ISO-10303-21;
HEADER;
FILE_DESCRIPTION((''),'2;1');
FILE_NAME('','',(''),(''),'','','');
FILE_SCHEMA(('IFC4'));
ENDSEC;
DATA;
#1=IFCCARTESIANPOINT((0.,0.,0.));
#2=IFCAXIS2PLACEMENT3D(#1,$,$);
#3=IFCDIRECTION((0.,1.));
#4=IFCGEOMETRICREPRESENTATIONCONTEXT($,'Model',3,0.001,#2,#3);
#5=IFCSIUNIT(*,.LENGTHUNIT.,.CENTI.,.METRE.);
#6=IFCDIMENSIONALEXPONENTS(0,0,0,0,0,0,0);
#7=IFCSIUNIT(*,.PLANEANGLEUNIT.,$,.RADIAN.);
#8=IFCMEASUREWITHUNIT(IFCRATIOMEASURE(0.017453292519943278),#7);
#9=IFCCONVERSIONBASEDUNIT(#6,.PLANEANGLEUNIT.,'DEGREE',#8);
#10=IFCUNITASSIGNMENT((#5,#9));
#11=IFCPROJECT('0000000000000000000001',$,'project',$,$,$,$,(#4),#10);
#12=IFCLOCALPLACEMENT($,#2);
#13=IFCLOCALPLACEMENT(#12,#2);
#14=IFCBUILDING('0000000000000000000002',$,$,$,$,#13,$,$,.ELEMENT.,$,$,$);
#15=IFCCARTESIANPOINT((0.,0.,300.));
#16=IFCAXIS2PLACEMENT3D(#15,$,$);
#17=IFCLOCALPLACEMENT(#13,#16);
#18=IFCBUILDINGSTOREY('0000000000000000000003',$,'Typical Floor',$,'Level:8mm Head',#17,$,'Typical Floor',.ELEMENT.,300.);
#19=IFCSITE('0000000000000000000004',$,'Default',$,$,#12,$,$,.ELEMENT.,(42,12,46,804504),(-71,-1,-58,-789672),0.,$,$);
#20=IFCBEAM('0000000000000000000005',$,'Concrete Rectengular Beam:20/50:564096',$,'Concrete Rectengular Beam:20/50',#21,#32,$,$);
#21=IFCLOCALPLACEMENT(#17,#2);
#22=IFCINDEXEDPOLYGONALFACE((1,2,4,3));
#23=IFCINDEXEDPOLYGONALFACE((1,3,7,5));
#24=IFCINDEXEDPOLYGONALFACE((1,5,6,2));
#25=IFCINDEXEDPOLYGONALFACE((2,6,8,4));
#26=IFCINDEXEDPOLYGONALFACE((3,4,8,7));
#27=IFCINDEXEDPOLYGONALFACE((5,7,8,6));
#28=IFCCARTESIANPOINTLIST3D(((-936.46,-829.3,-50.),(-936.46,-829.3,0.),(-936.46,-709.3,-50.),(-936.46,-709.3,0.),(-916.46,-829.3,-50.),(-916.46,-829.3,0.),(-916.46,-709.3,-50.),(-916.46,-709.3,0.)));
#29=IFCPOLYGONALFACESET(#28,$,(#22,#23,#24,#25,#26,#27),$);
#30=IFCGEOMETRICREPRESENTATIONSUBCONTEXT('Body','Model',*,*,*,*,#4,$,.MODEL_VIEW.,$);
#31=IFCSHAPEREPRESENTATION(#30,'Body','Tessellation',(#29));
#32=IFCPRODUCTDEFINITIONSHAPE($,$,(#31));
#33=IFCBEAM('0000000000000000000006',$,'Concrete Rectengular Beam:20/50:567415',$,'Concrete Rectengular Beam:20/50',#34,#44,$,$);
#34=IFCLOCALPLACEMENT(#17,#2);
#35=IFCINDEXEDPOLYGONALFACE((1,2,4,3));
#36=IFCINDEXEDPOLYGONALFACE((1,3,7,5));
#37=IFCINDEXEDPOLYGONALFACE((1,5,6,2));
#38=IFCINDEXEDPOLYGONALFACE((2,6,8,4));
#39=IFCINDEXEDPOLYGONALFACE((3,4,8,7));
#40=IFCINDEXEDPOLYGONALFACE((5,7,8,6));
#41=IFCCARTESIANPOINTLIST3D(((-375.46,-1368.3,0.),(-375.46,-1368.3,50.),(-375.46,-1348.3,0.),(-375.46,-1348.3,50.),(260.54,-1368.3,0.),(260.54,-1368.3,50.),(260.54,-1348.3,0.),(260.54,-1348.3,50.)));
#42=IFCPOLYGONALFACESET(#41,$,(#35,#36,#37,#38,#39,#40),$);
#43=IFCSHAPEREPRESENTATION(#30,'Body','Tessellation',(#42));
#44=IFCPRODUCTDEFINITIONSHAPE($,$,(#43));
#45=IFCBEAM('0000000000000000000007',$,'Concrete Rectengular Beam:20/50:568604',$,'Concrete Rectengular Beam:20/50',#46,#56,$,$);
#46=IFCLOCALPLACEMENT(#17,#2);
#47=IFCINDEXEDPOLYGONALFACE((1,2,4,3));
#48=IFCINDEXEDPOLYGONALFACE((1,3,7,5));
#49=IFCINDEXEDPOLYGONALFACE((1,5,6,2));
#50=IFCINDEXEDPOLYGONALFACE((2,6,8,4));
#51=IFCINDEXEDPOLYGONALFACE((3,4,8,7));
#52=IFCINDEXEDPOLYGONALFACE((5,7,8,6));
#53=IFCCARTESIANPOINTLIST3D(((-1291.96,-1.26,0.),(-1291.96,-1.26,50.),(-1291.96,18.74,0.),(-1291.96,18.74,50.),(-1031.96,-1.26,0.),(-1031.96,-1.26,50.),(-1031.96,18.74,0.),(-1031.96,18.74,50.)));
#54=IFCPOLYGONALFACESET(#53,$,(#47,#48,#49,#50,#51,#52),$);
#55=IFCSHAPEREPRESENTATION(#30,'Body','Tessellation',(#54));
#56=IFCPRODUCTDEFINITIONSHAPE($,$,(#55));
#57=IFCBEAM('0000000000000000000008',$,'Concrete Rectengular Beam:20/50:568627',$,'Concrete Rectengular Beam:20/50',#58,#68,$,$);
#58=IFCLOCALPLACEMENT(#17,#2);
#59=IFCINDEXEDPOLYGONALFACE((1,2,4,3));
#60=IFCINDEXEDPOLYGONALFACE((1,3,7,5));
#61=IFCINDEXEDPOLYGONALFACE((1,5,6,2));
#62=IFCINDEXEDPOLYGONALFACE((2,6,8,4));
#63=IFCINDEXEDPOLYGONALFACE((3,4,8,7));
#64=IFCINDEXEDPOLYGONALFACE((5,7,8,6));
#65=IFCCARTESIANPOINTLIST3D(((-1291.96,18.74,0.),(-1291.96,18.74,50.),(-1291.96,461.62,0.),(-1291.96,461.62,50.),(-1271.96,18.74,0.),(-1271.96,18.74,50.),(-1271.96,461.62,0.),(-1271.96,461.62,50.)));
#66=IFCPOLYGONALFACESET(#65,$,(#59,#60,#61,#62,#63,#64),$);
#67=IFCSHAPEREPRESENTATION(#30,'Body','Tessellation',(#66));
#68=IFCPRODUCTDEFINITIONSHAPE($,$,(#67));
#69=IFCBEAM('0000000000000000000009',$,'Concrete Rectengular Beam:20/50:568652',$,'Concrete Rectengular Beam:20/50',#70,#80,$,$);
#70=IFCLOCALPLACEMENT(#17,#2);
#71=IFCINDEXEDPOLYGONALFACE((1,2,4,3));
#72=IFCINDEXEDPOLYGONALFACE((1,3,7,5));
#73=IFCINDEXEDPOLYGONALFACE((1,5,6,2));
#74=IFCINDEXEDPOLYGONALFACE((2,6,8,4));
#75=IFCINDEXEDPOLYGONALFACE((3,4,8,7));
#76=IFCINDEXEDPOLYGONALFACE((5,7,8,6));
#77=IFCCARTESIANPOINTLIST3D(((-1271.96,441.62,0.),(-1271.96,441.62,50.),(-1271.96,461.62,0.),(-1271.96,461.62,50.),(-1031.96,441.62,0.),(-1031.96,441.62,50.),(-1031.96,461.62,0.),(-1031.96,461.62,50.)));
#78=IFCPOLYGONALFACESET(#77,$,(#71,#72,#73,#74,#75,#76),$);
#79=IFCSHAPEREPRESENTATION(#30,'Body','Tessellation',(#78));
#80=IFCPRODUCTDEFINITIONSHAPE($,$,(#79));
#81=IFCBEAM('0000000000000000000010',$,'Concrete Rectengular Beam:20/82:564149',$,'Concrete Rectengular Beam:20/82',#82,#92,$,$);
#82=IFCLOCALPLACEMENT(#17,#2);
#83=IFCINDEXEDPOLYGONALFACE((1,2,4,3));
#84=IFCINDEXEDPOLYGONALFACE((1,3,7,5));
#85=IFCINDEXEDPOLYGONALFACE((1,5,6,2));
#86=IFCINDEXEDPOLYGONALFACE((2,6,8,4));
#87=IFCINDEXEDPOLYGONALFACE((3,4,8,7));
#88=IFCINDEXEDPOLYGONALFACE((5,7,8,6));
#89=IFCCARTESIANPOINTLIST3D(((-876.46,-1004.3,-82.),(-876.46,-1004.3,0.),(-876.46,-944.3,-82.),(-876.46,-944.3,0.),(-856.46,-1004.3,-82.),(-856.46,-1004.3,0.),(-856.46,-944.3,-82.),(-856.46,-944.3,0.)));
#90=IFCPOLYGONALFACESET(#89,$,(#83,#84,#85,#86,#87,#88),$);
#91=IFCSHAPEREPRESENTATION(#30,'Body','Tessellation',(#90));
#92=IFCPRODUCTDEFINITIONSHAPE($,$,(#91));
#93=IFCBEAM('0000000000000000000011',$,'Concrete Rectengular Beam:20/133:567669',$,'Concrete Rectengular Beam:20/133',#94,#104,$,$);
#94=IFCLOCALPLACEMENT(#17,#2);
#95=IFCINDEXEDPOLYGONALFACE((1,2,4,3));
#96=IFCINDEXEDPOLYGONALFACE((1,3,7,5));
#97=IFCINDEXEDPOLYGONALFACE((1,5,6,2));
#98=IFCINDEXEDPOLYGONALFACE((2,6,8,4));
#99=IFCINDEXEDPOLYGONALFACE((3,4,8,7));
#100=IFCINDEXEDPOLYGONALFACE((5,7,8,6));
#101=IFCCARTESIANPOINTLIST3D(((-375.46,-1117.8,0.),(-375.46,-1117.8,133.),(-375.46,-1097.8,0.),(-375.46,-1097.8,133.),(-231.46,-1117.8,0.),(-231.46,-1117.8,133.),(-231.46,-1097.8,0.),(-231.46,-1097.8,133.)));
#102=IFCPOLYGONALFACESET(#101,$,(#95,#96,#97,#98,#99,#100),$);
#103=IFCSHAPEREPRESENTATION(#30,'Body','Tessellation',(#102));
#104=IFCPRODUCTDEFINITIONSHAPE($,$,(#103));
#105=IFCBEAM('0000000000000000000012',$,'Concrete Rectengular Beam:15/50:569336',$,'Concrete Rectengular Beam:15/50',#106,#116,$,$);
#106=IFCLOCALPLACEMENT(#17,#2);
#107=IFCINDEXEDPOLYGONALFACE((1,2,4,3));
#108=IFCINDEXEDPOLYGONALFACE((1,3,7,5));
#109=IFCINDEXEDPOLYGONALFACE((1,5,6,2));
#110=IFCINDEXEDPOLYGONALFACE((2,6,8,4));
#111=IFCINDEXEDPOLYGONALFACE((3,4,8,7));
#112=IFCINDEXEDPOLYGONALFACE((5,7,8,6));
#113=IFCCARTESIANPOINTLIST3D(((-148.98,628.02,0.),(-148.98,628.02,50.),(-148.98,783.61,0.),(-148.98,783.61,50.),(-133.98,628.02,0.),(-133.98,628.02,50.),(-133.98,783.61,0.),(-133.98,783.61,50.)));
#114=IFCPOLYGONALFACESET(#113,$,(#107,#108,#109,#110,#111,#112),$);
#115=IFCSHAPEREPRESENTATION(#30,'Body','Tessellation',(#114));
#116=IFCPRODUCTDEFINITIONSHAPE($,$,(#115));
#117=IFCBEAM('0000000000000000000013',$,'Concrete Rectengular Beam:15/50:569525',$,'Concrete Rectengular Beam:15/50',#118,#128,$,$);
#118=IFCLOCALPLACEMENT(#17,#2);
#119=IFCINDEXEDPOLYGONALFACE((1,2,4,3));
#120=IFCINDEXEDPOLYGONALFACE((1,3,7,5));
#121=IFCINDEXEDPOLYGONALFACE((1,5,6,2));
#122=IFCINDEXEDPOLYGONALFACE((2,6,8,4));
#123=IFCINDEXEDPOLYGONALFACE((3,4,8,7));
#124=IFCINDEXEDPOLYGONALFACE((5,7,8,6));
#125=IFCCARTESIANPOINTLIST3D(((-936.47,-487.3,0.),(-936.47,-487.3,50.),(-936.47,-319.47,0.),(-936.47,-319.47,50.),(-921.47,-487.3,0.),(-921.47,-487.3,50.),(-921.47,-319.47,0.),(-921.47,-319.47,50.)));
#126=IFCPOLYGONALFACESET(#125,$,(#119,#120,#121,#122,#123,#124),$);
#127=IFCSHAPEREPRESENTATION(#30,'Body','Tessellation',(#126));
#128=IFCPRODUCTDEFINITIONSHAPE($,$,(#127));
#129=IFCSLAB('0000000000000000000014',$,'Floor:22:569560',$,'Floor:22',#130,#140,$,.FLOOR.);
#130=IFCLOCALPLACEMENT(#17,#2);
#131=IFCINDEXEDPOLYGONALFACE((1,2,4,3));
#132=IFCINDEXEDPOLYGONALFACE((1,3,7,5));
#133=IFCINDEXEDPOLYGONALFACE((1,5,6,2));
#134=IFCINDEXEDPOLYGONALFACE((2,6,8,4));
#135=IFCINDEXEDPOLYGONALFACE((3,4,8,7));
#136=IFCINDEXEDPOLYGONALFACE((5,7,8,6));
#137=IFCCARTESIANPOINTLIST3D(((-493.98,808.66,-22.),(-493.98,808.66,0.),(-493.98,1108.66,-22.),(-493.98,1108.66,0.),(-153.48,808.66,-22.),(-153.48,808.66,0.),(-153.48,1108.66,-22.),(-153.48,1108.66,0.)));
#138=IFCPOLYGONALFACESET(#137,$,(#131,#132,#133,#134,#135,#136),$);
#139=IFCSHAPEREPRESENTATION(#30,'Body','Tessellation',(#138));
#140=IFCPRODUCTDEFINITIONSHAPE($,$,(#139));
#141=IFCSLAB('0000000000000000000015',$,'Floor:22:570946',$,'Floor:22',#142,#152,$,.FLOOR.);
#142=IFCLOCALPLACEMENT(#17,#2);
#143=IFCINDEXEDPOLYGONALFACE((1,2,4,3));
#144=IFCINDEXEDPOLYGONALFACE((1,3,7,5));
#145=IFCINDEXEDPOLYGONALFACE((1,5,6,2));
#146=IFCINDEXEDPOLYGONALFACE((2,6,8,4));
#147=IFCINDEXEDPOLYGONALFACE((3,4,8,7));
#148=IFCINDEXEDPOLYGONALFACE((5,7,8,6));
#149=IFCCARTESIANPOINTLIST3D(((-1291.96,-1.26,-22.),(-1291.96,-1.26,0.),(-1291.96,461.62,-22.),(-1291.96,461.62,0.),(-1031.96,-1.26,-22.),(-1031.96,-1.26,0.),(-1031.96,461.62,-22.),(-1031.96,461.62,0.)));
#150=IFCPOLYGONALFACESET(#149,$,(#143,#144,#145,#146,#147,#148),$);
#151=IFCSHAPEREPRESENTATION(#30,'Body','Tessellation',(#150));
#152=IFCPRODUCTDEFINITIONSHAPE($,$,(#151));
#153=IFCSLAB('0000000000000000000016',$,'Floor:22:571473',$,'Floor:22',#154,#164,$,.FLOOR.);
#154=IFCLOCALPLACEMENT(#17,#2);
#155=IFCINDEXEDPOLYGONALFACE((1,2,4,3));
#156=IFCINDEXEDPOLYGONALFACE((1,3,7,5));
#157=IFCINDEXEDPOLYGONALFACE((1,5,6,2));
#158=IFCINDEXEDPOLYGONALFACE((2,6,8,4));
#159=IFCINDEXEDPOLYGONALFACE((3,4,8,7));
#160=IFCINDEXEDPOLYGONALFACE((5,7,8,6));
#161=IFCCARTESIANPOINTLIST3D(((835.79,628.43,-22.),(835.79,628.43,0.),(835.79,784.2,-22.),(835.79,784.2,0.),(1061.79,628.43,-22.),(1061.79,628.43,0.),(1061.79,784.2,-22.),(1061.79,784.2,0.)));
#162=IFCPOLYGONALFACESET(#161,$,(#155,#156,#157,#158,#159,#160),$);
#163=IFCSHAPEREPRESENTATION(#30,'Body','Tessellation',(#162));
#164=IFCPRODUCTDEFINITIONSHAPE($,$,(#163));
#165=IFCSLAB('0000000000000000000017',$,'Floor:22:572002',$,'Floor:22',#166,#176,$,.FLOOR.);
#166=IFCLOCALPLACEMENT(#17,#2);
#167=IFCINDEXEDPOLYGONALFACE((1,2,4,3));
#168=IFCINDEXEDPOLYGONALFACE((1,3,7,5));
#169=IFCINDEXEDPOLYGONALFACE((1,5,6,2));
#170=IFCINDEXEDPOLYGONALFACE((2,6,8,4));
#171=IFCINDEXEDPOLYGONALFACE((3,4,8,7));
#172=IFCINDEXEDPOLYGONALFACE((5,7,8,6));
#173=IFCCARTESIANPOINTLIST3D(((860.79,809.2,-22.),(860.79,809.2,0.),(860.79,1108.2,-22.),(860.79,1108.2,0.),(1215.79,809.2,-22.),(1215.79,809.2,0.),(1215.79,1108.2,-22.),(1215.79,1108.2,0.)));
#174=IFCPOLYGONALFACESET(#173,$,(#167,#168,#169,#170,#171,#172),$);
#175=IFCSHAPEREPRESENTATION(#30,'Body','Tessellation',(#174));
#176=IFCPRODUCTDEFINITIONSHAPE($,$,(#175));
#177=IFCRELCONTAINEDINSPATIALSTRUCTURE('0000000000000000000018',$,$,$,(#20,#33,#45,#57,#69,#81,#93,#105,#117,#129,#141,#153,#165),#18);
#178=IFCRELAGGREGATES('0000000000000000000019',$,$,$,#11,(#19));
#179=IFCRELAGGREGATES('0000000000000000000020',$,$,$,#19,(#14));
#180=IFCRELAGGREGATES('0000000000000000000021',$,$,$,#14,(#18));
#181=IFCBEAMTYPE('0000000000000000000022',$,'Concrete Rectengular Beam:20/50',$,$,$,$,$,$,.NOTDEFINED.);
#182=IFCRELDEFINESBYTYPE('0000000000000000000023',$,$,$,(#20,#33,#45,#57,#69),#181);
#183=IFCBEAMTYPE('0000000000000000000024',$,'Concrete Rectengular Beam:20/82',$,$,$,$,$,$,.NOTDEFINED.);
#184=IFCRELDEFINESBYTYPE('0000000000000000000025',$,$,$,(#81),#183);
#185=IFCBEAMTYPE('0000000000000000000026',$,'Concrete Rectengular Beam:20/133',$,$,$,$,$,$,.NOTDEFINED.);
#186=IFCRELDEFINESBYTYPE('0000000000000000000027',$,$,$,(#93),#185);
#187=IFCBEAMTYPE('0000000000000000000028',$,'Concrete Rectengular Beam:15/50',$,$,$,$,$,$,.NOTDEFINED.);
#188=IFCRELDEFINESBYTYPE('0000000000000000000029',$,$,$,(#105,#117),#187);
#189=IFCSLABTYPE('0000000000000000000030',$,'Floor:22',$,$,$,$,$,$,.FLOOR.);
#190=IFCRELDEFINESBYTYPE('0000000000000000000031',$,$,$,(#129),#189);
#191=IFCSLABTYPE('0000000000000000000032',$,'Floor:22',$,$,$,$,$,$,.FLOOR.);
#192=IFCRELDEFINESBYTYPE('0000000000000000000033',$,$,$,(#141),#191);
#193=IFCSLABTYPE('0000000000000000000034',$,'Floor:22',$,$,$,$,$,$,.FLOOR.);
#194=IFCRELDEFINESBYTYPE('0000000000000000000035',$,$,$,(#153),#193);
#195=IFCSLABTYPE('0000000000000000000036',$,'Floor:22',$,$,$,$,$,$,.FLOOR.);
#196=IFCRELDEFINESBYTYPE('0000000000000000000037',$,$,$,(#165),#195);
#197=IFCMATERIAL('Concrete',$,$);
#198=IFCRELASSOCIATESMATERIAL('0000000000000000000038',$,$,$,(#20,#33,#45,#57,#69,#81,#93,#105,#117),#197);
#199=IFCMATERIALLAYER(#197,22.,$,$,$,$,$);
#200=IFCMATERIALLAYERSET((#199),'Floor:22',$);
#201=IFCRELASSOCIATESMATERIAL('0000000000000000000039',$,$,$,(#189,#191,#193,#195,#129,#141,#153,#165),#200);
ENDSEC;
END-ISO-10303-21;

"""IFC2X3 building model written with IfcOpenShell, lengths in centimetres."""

from ifc_helpers import new_model, entity, si_unit, converted_unit, direction, frame, frame_2d, origin, origin_2d_with_axis, place, context, subcontext, project, spatial, rectangle, extrude, material, layer, layer_set, layer_usage, type_object, element, save


model = new_model("IFC2X3")

# Units and contexts
model_context = context("Model", 3, precision=0.001, world=origin(), true_north=direction((0.0, 1.0)))
body_context = subcontext(model_context, "Body", "Model", "MODEL_VIEW")
ifc_project = project(units=[si_unit("LENGTHUNIT", "METRE", prefix="CENTI"), converted_unit("PLANEANGLEUNIT", "DEGREE", entity("IfcRatioMeasure", 0.017453292519943278), si_unit("PLANEANGLEUNIT", "RADIAN"), dimensions=[0, 0, 0, 0, 0, 0, 0])], contexts=[model_context])

# Site, building, storey
site_placement = place(None, origin())
site = spatial("IfcSite", under=ifc_project, at=site_placement, Name="Default", CompositionType="ELEMENT", RefLatitude=(42, 12, 46, 804504), RefLongitude=(-71, -1, -58, -789672), RefElevation=0.0)
building_placement = place(site_placement, origin())
building = spatial("IfcBuilding", under=site, at=building_placement, CompositionType="ELEMENT")
storey_placement = place(building_placement, frame((0.0, 0.0, 300.0)))
storey = spatial("IfcBuildingStorey", under=building, at=storey_placement, Name="Typical Floor", ObjectType="Level:8mm Head", LongName="Typical Floor", CompositionType="ELEMENT", Elevation=300.0)

# Beams
ifc_material = material(Name="Concrete")
beam_type_1 = type_object("IfcBeamType", Name="Concrete Rectengular Beam:20/50", PredefinedType="NOTDEFINED")
beam_1_placement = place(storey_placement, frame((-926.46, -699.3, 0.0), z_axis=(0.0, 0.0, 1.0), x_axis=(0.0, -1.0, 0.0)))
element("IfcBeam", 1, at=beam_1_placement, inside=storey, type_object=beam_type_1, material=ifc_material, Name="Concrete Rectengular Beam:20/50:564096", ObjectType="Concrete Rectengular Beam:20/50", context=body_context, shape_type="SweptSolid", body=[
    extrude(rectangle(XDim=50.0, YDim=20.0, at=origin_2d_with_axis()), frame((10.0, 0.0, -25.0), z_axis=(1.0, 0.0, 0.0), x_axis=(0.0, 0.0, -1.0)), (0.0, 0.0, 1.0), 120.0),
])
beam_2_placement = place(storey_placement, frame((-375.46, -1358.3, 0.0)))
element("IfcBeam", 2, at=beam_2_placement, inside=storey, type_object=beam_type_1, material=ifc_material, Name="Concrete Rectengular Beam:20/50:567415", ObjectType="Concrete Rectengular Beam:20/50", context=body_context, shape_type="SweptSolid", body=[
    extrude(rectangle(XDim=50.0, YDim=20.0, at=frame_2d((0.0, 0.0), x_axis=(1.0, 0.0))), frame((0.0, 0.0, 25.0), z_axis=(1.0, 0.0, 0.0), x_axis=(0.0, 0.0, -1.0)), (0.0, 0.0, 1.0), 636.0),
])
beam_3_placement = place(storey_placement, frame((-1031.96, 8.74, 0.0), z_axis=(0.0, 0.0, 1.0), x_axis=(-1.0, 0.0, 0.0)))
element("IfcBeam", 3, at=beam_3_placement, inside=storey, type_object=beam_type_1, material=ifc_material, Name="Concrete Rectengular Beam:20/50:568604", ObjectType="Concrete Rectengular Beam:20/50", context=body_context, shape_type="SweptSolid", body=[
    extrude(rectangle(XDim=50.0, YDim=20.0, at=frame_2d((0.0, 0.0), x_axis=(1.0, 0.0))), frame((0.0, 0.0, 25.0), z_axis=(1.0, 0.0, 0.0), x_axis=(0.0, 0.0, -1.0)), (0.0, 0.0, 1.0), 260.0),
])
beam_4_placement = place(storey_placement, frame((-1281.96, 8.74, 0.0), z_axis=(0.0, 0.0, 1.0), x_axis=(0.0, 1.0, 0.0)))
element("IfcBeam", 4, at=beam_4_placement, inside=storey, type_object=beam_type_1, material=ifc_material, Name="Concrete Rectengular Beam:20/50:568627", ObjectType="Concrete Rectengular Beam:20/50", context=body_context, shape_type="SweptSolid", body=[
    extrude(rectangle(XDim=50.0, YDim=20.0, at=frame_2d((0.0, 0.0), x_axis=(1.0, 0.0))), frame((10.0, 0.0, 25.0), z_axis=(1.0, 0.0, 0.0), x_axis=(0.0, 0.0, -1.0)), (0.0, 0.0, 1.0), 442.88),
])
beam_5_placement = place(storey_placement, frame((-1281.96, 451.62, 0.0)))
element("IfcBeam", 5, at=beam_5_placement, inside=storey, type_object=beam_type_1, material=ifc_material, Name="Concrete Rectengular Beam:20/50:568652", ObjectType="Concrete Rectengular Beam:20/50", context=body_context, shape_type="SweptSolid", body=[
    extrude(rectangle(XDim=50.0, YDim=20.0, at=frame_2d((0.0, 0.0), x_axis=(1.0, 0.0))), frame((10.0, 0.0, 25.0), z_axis=(1.0, 0.0, 0.0), x_axis=(0.0, 0.0, -1.0)), (0.0, 0.0, 1.0), 240.0),
])
beam_type_2 = type_object("IfcBeamType", Name="Concrete Rectengular Beam:20/82", PredefinedType="NOTDEFINED")
beam_6_placement = place(storey_placement, frame((-866.46, -934.3, 0.0), z_axis=(0.0, 0.0, 1.0), x_axis=(0.0, -1.0, 0.0)))
element("IfcBeam", 6, at=beam_6_placement, inside=storey, type_object=beam_type_2, material=ifc_material, Name="Concrete Rectengular Beam:20/82:564149", ObjectType="Concrete Rectengular Beam:20/82", context=body_context, shape_type="SweptSolid", body=[
    extrude(rectangle(XDim=82.0, YDim=20.0, at=frame_2d((0.0, 0.0), x_axis=(1.0, 0.0))), frame((10.0, 0.0, -41.0), z_axis=(1.0, 0.0, 0.0), x_axis=(0.0, 0.0, -1.0)), (0.0, 0.0, 1.0), 60.0),
])
beam_type_3 = type_object("IfcBeamType", Name="Concrete Rectengular Beam:20/133", PredefinedType="NOTDEFINED")
beam_7_placement = place(storey_placement, frame((-231.46, -1107.8, 0.0), z_axis=(0.0, 0.0, 1.0), x_axis=(-1.0, 0.0, 0.0)))
element("IfcBeam", 7, at=beam_7_placement, inside=storey, type_object=beam_type_3, material=ifc_material, Name="Concrete Rectengular Beam:20/133:567669", ObjectType="Concrete Rectengular Beam:20/133", context=body_context, shape_type="SweptSolid", body=[
    extrude(rectangle(XDim=133.0, YDim=20.0, at=frame_2d((0.0, 0.0), x_axis=(1.0, 0.0))), frame((0.0, 0.0, 66.5), z_axis=(1.0, 0.0, 0.0), x_axis=(0.0, 0.0, -1.0)), (0.0, 0.0, 1.0), 144.0),
])
beam_type_4 = type_object("IfcBeamType", Name="Concrete Rectengular Beam:15/50", PredefinedType="NOTDEFINED")
beam_8_placement = place(storey_placement, frame((-141.48, 628.02, 0.0), z_axis=(0.0, 0.0, 1.0), x_axis=(0.0, 1.0, 0.0)))
element("IfcBeam", 8, at=beam_8_placement, inside=storey, type_object=beam_type_4, material=ifc_material, Name="Concrete Rectengular Beam:15/50:569336", ObjectType="Concrete Rectengular Beam:15/50", context=body_context, shape_type="SweptSolid", body=[
    extrude(rectangle(XDim=50.0, YDim=15.0, at=origin_2d_with_axis()), frame((0.0, 0.0, 25.0), z_axis=(1.0, 0.0, 0.0), x_axis=(0.0, 0.0, -1.0)), (0.0, 0.0, 1.0), 155.59),
])
beam_9_placement = place(storey_placement, frame((-928.97, -487.3, 0.0), z_axis=(0.0, 0.0, 1.0), x_axis=(0.0, 1.0, 0.0)))
element("IfcBeam", 9, at=beam_9_placement, inside=storey, type_object=beam_type_4, material=ifc_material, Name="Concrete Rectengular Beam:15/50:569525", ObjectType="Concrete Rectengular Beam:15/50", context=body_context, shape_type="SweptSolid", body=[
    extrude(rectangle(XDim=50.0, YDim=15.0, at=frame_2d((0.0, 0.0), x_axis=(1.0, 0.0))), frame((0.0, 0.0, 25.0), z_axis=(1.0, 0.0, 0.0), x_axis=(0.0, 0.0, -1.0)), (0.0, 0.0, 1.0), 167.82),
])

# Slabs
ifc_layer = layer(ifc_material, 22.0)
ifc_layer_set = layer_set([ifc_layer], Name="Floor:22")
ifc_layer_usage_1 = layer_usage(ifc_layer_set, "AXIS3", "POSITIVE", 0.0)
slab_type_1 = type_object("IfcSlabType", Name="Floor:22", PredefinedType="FLOOR", material=ifc_layer_set)
slab_1_placement = place(storey_placement, origin())
element("IfcSlab", 10, at=slab_1_placement, inside=storey, type_object=slab_type_1, material=ifc_layer_usage_1, Name="Floor:22:569560", ObjectType="Floor:22", PredefinedType="FLOOR", context=body_context, shape_type="SweptSolid", body=[
    extrude(rectangle(XDim=300.0, YDim=340.5, at=frame_2d((0.0, 0.0), x_axis=(1.0, 0.0))), frame((-323.73, 958.66, 0.0), z_axis=(0.0, 0.0, -1.0), x_axis=(0.0, 1.0, 0.0)), (0.0, 0.0, 1.0), 22.0),
])
ifc_layer_usage_2 = layer_usage(ifc_layer_set, "AXIS3", "POSITIVE", 0.0)
slab_type_2 = type_object("IfcSlabType", Name="Floor:22", PredefinedType="FLOOR", material=ifc_layer_set)
slab_2_placement = place(storey_placement, origin())
element("IfcSlab", 11, at=slab_2_placement, inside=storey, type_object=slab_type_2, material=ifc_layer_usage_2, Name="Floor:22:570946", ObjectType="Floor:22", PredefinedType="FLOOR", context=body_context, shape_type="SweptSolid", body=[
    extrude(rectangle(XDim=462.88, YDim=260.0, at=frame_2d((0.0, 0.0), x_axis=(1.0, 0.0))), frame((-1161.96, 230.18, 0.0), z_axis=(0.0, 0.0, -1.0), x_axis=(0.0, 1.0, 0.0)), (0.0, 0.0, 1.0), 22.0),
])
ifc_layer_usage_3 = layer_usage(ifc_layer_set, "AXIS3", "POSITIVE", 0.0)
slab_type_3 = type_object("IfcSlabType", Name="Floor:22", PredefinedType="FLOOR", material=ifc_layer_set)
slab_3_placement = place(storey_placement, origin())
element("IfcSlab", 12, at=slab_3_placement, inside=storey, type_object=slab_type_3, material=ifc_layer_usage_3, Name="Floor:22:571473", ObjectType="Floor:22", PredefinedType="FLOOR", context=body_context, shape_type="SweptSolid", body=[
    extrude(rectangle(XDim=155.77, YDim=226.0, at=frame_2d((0.0, 0.0), x_axis=(1.0, 0.0))), frame((948.79, 706.32, 0.0), z_axis=(0.0, 0.0, -1.0), x_axis=(0.0, 1.0, 0.0)), (0.0, 0.0, 1.0), 22.0),
])
ifc_layer_usage_4 = layer_usage(ifc_layer_set, "AXIS3", "POSITIVE", 0.0)
slab_type_4 = type_object("IfcSlabType", Name="Floor:22", PredefinedType="FLOOR", material=ifc_layer_set)
slab_4_placement = place(storey_placement, origin())
element("IfcSlab", 13, at=slab_4_placement, inside=storey, type_object=slab_type_4, material=ifc_layer_usage_4, Name="Floor:22:572002", ObjectType="Floor:22", PredefinedType="FLOOR", context=body_context, shape_type="SweptSolid", body=[
    extrude(rectangle(XDim=299.0, YDim=355.0, at=frame_2d((0.0, 0.0), x_axis=(1.0, 0.0))), frame((1038.29, 958.7, 0.0), z_axis=(0.0, 0.0, -1.0), x_axis=(0.0, 1.0, 0.0)), (0.0, 0.0, 1.0), 22.0),
])

save(model, "model.ifc")
